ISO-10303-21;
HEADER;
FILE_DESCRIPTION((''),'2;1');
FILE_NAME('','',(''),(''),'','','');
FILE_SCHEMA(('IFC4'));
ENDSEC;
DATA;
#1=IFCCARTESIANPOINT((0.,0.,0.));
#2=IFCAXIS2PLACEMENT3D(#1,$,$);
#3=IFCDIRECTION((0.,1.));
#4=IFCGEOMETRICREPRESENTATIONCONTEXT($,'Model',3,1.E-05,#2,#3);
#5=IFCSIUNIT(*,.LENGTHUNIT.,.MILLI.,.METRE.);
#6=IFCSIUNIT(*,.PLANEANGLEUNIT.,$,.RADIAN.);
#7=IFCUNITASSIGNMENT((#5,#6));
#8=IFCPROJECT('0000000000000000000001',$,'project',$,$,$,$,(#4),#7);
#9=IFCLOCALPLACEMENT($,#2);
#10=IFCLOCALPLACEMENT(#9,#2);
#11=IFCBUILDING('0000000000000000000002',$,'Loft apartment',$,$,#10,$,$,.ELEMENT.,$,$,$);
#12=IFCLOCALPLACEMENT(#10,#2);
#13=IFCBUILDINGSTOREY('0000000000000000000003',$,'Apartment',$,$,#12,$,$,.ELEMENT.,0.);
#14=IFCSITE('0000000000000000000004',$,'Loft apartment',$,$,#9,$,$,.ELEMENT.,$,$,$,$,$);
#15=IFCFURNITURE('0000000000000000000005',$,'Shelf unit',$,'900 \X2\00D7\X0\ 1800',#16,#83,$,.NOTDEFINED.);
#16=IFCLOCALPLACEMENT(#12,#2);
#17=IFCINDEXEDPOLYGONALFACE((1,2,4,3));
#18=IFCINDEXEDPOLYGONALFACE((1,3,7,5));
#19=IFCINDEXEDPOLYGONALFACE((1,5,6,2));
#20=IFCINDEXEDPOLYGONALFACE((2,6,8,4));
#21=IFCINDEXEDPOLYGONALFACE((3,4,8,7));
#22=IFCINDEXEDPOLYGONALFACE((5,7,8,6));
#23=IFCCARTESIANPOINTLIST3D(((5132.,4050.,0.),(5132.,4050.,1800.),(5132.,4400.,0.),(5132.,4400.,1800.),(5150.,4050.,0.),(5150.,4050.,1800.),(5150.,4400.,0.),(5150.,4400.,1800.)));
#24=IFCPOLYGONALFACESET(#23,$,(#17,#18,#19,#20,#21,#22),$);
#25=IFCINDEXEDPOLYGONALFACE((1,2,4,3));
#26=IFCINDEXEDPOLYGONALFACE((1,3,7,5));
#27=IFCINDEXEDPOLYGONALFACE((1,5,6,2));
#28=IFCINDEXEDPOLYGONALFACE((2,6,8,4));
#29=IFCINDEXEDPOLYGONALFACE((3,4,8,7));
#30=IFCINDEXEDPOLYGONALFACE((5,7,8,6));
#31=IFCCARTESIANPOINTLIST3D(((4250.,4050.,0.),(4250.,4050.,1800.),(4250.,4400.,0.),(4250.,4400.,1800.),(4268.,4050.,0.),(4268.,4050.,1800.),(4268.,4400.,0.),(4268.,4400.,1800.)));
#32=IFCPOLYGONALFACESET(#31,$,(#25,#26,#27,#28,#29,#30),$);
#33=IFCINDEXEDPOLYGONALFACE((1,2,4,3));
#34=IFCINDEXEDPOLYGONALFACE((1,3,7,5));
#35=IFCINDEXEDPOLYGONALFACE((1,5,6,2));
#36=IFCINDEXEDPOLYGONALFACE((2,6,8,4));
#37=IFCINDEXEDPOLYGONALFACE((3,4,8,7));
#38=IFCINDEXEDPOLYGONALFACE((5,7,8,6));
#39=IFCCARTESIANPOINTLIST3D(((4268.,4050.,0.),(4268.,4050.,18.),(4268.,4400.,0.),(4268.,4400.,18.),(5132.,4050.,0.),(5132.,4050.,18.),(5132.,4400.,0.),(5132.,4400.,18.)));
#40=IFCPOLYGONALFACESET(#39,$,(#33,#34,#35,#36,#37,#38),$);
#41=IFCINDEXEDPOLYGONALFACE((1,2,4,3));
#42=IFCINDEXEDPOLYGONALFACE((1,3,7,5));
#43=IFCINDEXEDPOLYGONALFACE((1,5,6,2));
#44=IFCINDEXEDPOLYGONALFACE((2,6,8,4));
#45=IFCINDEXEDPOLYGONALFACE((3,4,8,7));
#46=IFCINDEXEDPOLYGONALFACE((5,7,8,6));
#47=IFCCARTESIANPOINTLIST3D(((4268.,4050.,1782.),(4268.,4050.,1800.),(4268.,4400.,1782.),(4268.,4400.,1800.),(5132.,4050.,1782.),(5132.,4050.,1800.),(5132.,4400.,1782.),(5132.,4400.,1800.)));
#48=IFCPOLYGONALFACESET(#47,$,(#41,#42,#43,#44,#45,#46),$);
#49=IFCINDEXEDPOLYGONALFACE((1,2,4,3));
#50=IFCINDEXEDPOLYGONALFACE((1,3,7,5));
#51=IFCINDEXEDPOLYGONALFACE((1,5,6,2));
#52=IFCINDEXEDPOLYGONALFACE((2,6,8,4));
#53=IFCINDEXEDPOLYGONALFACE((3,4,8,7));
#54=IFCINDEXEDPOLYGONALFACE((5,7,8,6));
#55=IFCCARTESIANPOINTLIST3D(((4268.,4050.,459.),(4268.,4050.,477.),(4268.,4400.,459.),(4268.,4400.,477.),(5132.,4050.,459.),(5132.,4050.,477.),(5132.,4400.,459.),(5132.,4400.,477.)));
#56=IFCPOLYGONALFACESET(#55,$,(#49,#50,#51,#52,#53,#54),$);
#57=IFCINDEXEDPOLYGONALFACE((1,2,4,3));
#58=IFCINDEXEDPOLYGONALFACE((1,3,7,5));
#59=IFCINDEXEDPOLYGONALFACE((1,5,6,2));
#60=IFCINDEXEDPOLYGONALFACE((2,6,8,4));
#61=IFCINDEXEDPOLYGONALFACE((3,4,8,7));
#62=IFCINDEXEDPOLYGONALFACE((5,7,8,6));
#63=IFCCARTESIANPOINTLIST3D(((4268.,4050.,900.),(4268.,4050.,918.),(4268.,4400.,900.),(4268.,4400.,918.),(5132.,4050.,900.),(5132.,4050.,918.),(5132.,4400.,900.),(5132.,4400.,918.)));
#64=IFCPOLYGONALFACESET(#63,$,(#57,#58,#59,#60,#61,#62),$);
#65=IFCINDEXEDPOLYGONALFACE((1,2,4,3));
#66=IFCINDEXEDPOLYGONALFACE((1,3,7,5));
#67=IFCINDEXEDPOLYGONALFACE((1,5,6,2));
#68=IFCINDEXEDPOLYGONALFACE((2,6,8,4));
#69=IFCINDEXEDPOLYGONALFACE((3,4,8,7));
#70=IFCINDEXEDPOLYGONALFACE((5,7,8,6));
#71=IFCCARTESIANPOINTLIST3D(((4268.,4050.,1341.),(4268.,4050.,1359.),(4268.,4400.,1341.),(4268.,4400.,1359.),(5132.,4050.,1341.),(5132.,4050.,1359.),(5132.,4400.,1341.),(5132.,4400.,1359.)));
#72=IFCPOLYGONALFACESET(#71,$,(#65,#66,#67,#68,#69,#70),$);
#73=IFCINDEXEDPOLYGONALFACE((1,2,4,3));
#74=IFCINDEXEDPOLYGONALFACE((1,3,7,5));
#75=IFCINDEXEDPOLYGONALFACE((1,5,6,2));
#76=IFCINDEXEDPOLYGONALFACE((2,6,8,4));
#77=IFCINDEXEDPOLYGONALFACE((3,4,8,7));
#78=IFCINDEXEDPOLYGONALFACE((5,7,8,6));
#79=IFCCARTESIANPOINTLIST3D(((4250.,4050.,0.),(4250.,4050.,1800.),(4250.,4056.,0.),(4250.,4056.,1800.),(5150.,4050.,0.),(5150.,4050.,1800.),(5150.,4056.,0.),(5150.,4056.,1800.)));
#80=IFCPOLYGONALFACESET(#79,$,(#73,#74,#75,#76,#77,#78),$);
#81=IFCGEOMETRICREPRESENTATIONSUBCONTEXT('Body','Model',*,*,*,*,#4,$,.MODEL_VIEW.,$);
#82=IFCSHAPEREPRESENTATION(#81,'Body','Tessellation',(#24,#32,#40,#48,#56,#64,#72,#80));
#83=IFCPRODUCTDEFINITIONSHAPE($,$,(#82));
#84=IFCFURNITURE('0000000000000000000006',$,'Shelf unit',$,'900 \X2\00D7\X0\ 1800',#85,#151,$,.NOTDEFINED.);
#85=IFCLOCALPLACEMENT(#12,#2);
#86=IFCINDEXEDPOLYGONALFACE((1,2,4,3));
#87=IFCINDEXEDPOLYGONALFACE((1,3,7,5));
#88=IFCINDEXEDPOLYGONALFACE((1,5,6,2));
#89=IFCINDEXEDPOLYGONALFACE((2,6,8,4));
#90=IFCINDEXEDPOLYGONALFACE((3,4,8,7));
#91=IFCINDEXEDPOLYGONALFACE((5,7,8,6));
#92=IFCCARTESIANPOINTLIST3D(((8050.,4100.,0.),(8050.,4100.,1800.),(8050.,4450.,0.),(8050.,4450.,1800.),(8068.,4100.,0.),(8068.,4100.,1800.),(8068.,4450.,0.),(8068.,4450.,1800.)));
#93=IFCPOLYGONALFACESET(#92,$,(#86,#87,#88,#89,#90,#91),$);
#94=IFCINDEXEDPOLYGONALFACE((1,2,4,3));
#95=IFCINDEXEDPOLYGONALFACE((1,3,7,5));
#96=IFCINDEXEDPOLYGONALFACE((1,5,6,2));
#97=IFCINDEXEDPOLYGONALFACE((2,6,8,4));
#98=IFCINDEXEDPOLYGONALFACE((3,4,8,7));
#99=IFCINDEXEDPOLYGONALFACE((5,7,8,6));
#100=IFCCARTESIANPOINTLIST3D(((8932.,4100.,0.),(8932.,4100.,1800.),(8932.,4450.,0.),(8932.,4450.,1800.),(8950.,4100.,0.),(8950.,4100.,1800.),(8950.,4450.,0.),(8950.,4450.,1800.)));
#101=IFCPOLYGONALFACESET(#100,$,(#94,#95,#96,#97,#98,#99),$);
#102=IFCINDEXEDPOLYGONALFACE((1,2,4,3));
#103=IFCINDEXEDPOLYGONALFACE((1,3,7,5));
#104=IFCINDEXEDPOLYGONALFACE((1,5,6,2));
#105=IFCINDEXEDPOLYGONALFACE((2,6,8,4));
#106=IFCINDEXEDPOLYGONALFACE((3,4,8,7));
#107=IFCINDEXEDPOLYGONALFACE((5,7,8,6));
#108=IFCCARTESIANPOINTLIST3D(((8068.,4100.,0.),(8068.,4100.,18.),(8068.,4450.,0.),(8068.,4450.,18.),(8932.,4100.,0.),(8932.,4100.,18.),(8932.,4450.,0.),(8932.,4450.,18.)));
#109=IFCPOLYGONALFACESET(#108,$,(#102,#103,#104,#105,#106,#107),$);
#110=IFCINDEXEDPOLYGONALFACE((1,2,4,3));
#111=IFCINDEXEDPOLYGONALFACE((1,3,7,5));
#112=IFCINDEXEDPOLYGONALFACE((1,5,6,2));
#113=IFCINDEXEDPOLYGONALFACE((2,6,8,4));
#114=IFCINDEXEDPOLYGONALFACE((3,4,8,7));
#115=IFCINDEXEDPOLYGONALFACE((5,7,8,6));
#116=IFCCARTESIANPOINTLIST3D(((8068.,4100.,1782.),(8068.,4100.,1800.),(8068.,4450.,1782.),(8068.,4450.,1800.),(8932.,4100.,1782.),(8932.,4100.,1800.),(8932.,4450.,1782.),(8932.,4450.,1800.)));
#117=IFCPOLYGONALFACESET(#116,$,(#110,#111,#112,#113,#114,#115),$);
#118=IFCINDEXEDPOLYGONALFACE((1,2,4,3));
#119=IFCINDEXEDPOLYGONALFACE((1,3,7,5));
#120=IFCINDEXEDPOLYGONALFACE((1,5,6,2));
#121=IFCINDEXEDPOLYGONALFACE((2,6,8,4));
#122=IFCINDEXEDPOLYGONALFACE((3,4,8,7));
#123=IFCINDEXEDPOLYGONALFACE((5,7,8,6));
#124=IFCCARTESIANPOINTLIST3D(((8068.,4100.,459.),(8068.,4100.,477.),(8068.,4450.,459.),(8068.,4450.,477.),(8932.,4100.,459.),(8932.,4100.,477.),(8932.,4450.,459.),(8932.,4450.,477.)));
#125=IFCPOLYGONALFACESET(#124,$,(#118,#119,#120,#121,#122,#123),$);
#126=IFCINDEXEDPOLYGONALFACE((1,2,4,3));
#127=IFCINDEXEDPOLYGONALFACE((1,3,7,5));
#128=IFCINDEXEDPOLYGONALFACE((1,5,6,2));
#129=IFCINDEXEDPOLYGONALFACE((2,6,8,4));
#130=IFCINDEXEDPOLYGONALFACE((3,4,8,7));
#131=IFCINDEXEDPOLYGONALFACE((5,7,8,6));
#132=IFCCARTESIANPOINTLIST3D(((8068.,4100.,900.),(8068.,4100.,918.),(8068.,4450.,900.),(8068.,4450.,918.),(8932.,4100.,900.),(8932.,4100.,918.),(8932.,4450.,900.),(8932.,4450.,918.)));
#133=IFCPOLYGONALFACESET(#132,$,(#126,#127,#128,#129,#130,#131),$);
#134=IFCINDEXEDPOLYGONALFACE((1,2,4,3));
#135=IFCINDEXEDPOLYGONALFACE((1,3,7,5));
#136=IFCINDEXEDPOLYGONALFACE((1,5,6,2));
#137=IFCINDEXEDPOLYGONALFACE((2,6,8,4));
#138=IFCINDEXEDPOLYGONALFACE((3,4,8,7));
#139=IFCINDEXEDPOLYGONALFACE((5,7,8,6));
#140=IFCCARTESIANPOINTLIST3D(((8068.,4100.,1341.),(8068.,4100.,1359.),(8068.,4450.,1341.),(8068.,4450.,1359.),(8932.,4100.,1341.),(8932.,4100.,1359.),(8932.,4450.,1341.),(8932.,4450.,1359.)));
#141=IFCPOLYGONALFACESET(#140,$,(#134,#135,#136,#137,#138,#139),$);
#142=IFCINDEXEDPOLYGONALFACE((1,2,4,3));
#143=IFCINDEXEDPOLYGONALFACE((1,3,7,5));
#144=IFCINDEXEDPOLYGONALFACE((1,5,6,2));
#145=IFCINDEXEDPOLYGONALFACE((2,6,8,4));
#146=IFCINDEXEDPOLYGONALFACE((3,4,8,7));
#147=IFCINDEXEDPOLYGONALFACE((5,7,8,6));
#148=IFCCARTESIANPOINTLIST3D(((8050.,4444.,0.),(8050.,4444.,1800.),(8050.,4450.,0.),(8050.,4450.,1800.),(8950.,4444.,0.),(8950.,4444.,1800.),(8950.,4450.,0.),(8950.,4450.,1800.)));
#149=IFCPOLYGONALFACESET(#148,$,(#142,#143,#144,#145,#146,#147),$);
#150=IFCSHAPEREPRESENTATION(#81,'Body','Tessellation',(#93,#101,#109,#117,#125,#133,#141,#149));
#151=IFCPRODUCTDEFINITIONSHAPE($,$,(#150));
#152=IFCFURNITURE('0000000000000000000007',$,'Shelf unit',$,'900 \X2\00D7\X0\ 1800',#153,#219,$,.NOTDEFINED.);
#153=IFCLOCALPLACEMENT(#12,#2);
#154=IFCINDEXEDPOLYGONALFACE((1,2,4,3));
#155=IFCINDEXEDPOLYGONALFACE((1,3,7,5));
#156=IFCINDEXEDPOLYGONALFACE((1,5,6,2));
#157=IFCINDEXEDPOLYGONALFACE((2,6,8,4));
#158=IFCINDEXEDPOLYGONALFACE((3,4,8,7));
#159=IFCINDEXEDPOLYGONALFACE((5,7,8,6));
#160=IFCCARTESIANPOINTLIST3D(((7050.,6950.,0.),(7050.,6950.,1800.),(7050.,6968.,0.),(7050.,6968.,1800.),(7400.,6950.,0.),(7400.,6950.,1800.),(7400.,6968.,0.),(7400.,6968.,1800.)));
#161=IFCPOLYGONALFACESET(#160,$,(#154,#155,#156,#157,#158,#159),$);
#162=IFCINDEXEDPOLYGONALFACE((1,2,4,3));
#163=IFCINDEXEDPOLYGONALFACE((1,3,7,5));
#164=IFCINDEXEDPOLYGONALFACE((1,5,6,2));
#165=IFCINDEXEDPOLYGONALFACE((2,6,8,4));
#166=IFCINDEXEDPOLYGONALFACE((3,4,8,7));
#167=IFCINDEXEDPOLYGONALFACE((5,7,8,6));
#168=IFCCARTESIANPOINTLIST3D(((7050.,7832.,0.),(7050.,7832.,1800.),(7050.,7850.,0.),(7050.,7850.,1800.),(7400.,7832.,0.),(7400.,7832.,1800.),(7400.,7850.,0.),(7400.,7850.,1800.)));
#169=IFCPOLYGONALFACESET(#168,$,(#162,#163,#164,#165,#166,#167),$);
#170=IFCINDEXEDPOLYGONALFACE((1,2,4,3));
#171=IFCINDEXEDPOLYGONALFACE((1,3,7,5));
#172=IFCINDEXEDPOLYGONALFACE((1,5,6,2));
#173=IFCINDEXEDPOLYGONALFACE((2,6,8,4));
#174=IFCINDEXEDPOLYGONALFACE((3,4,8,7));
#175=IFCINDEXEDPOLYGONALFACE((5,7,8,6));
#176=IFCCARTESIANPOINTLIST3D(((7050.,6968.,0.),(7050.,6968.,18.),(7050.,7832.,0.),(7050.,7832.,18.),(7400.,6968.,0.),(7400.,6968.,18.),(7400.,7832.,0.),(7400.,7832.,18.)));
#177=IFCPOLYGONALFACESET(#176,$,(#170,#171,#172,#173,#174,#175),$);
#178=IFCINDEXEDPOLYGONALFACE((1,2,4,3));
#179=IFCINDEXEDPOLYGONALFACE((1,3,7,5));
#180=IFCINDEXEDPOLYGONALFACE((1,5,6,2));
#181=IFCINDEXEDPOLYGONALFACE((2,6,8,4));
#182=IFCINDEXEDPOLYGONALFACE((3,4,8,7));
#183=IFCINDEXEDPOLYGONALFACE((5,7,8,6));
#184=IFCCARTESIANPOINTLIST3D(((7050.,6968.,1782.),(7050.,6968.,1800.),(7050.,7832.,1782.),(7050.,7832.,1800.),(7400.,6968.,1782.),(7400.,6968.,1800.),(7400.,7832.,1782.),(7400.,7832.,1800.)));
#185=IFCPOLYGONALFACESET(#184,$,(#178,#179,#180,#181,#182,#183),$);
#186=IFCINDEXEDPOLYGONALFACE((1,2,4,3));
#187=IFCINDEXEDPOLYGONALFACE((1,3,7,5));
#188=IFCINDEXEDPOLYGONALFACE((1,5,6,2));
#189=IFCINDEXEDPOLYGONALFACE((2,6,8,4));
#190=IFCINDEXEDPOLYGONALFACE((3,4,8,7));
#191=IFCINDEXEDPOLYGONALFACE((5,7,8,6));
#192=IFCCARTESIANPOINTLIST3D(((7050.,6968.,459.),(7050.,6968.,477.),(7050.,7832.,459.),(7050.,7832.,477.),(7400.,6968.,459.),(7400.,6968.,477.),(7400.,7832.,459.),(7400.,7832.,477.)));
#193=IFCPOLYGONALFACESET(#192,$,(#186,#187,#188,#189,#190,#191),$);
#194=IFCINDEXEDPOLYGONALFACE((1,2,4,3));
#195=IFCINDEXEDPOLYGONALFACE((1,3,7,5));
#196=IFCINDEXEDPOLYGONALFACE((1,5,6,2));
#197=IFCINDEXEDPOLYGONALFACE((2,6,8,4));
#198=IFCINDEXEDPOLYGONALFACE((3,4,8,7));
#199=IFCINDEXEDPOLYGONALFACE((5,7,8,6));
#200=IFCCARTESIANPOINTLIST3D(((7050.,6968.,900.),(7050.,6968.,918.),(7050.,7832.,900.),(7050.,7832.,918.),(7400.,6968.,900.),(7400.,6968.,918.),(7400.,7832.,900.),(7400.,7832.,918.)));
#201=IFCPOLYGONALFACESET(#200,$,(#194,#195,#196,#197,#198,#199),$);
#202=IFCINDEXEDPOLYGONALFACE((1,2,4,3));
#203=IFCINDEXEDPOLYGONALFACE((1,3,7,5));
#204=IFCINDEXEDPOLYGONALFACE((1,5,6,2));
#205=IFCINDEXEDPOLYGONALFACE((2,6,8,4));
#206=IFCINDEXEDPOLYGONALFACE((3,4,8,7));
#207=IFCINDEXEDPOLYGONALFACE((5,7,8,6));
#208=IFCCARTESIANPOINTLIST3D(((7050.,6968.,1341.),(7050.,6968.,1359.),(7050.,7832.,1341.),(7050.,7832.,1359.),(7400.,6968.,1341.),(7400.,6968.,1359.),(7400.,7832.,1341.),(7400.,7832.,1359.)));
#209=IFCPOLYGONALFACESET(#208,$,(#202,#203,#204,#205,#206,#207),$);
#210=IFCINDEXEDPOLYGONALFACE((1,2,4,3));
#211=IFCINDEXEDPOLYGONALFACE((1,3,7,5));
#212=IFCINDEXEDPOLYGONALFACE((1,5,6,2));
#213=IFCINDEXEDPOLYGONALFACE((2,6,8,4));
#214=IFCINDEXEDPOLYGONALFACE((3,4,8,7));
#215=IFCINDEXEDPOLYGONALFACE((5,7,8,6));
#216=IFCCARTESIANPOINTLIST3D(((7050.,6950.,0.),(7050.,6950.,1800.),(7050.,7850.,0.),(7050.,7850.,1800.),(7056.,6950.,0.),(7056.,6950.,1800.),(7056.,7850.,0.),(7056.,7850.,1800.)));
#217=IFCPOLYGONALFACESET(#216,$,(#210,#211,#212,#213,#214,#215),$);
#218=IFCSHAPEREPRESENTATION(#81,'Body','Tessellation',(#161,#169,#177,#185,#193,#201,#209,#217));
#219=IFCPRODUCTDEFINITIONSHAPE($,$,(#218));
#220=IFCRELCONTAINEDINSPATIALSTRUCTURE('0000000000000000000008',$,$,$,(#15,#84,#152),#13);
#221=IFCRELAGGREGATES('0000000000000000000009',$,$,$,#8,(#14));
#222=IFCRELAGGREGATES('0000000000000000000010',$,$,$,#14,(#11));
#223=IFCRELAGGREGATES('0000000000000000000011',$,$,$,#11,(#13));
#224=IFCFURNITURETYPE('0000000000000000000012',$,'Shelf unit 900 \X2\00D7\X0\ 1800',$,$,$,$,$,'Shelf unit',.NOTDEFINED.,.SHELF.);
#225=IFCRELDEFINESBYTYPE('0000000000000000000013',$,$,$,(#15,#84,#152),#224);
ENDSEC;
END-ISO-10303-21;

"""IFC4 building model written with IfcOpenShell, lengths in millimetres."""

from ifc_helpers import new_model, si_unit, direction, frame, origin, place, context, subcontext, project, spatial, polyline, outline, extrude, source, transform, mapped, type_object, type_shapes, element, save


model = new_model("IFC4")

# Units and contexts
model_context = context("Model", 3, precision=1e-05, world=origin(), true_north=direction((0.0, 1.0)))
body_context = subcontext(model_context, "Body", "Model", "MODEL_VIEW")
ifc_project = project(units=[si_unit("LENGTHUNIT", "METRE", prefix="MILLI"), si_unit("PLANEANGLEUNIT", "RADIAN")], contexts=[model_context])

# Site, building, storey
site_placement = place(None, origin())
site = spatial("IfcSite", under=ifc_project, at=site_placement, Name="Loft apartment", CompositionType="ELEMENT")
building_placement = place(site_placement, origin())
building = spatial("IfcBuilding", under=site, at=building_placement, Name="Loft apartment", CompositionType="ELEMENT")
storey_placement = place(building_placement, origin())
storey = spatial("IfcBuildingStorey", under=building, at=storey_placement, Name="Apartment", CompositionType="ELEMENT", Elevation=0.0)

# Furniture
furniture_type_1 = type_object("IfcFurnitureType", Name="Shelf unit 900 × 1800", ElementType="Shelf unit", AssemblyPlace="NOTDEFINED", PredefinedType="SHELF")
shared_shape_1 = source(origin(), body_context, "Body", "SweptSolid", [
    extrude(outline(polyline([(-450.0, 0.0), (-432.0, 0.0), (-432.0, 350.0), (-450.0, 350.0), (-450.0, 0.0)])), origin(), (0.0, 0.0, 1.0), 1800.0),
    extrude(outline(polyline([(432.0, 0.0), (450.0, 0.0), (450.0, 350.0), (432.0, 350.0), (432.0, 0.0)])), origin(), (0.0, 0.0, 1.0), 1800.0),
    extrude(outline(polyline([(-432.0, 0.0), (432.0, 0.0), (432.0, 350.0), (-432.0, 350.0), (-432.0, 0.0)])), origin(), (0.0, 0.0, 1.0), 18.0),
    extrude(outline(polyline([(-432.0, 0.0), (432.0, 0.0), (432.0, 350.0), (-432.0, 350.0), (-432.0, 0.0)])), frame((0.0, 0.0, 1782.0)), (0.0, 0.0, 1.0), 18.0),
    extrude(outline(polyline([(-432.0, 0.0), (432.0, 0.0), (432.0, 350.0), (-432.0, 350.0), (-432.0, 0.0)])), frame((0.0, 0.0, 459.0)), (0.0, 0.0, 1.0), 18.0),
    extrude(outline(polyline([(-432.0, 0.0), (432.0, 0.0), (432.0, 350.0), (-432.0, 350.0), (-432.0, 0.0)])), frame((0.0, 0.0, 900.0)), (0.0, 0.0, 1.0), 18.0),
    extrude(outline(polyline([(-432.0, 0.0), (432.0, 0.0), (432.0, 350.0), (-432.0, 350.0), (-432.0, 0.0)])), frame((0.0, 0.0, 1341.0)), (0.0, 0.0, 1.0), 18.0),
    extrude(outline(polyline([(-450.0, 344.0), (450.0, 344.0), (450.0, 350.0), (-450.0, 350.0), (-450.0, 344.0)])), origin(), (0.0, 0.0, 1.0), 1800.0),
])
type_shapes(furniture_type_1, [shared_shape_1])
for number, where, z_axis, x_axis, name in (
    (1, (4700.0, 4400.0, 0.0), (0.0, 0.0, 1.0), (-1.0, 0.0, 0.0), "Shelf unit"),
    (2, (8500.0, 4100.0, 0.0), (0.0, 0.0, 1.0), (1.0, 0.0, 0.0), "Shelf unit"),
    (3, (7400.0, 7400.0, 0.0), (0.0, 0.0, 1.0), (0.0, 1.0, 0.0), "Shelf unit"),
):
    element("IfcFurniture", number, at=place(storey_placement, frame(where, z_axis=z_axis, x_axis=x_axis)), inside=storey, type_object=furniture_type_1, Name=name, ObjectType="900 × 1800", PredefinedType="NOTDEFINED", context=body_context, shape_type="MappedRepresentation", body=[
        mapped(shared_shape_1, transform((0.0, 0.0, 0.0))),
    ])

save(model, "model.ifc")
